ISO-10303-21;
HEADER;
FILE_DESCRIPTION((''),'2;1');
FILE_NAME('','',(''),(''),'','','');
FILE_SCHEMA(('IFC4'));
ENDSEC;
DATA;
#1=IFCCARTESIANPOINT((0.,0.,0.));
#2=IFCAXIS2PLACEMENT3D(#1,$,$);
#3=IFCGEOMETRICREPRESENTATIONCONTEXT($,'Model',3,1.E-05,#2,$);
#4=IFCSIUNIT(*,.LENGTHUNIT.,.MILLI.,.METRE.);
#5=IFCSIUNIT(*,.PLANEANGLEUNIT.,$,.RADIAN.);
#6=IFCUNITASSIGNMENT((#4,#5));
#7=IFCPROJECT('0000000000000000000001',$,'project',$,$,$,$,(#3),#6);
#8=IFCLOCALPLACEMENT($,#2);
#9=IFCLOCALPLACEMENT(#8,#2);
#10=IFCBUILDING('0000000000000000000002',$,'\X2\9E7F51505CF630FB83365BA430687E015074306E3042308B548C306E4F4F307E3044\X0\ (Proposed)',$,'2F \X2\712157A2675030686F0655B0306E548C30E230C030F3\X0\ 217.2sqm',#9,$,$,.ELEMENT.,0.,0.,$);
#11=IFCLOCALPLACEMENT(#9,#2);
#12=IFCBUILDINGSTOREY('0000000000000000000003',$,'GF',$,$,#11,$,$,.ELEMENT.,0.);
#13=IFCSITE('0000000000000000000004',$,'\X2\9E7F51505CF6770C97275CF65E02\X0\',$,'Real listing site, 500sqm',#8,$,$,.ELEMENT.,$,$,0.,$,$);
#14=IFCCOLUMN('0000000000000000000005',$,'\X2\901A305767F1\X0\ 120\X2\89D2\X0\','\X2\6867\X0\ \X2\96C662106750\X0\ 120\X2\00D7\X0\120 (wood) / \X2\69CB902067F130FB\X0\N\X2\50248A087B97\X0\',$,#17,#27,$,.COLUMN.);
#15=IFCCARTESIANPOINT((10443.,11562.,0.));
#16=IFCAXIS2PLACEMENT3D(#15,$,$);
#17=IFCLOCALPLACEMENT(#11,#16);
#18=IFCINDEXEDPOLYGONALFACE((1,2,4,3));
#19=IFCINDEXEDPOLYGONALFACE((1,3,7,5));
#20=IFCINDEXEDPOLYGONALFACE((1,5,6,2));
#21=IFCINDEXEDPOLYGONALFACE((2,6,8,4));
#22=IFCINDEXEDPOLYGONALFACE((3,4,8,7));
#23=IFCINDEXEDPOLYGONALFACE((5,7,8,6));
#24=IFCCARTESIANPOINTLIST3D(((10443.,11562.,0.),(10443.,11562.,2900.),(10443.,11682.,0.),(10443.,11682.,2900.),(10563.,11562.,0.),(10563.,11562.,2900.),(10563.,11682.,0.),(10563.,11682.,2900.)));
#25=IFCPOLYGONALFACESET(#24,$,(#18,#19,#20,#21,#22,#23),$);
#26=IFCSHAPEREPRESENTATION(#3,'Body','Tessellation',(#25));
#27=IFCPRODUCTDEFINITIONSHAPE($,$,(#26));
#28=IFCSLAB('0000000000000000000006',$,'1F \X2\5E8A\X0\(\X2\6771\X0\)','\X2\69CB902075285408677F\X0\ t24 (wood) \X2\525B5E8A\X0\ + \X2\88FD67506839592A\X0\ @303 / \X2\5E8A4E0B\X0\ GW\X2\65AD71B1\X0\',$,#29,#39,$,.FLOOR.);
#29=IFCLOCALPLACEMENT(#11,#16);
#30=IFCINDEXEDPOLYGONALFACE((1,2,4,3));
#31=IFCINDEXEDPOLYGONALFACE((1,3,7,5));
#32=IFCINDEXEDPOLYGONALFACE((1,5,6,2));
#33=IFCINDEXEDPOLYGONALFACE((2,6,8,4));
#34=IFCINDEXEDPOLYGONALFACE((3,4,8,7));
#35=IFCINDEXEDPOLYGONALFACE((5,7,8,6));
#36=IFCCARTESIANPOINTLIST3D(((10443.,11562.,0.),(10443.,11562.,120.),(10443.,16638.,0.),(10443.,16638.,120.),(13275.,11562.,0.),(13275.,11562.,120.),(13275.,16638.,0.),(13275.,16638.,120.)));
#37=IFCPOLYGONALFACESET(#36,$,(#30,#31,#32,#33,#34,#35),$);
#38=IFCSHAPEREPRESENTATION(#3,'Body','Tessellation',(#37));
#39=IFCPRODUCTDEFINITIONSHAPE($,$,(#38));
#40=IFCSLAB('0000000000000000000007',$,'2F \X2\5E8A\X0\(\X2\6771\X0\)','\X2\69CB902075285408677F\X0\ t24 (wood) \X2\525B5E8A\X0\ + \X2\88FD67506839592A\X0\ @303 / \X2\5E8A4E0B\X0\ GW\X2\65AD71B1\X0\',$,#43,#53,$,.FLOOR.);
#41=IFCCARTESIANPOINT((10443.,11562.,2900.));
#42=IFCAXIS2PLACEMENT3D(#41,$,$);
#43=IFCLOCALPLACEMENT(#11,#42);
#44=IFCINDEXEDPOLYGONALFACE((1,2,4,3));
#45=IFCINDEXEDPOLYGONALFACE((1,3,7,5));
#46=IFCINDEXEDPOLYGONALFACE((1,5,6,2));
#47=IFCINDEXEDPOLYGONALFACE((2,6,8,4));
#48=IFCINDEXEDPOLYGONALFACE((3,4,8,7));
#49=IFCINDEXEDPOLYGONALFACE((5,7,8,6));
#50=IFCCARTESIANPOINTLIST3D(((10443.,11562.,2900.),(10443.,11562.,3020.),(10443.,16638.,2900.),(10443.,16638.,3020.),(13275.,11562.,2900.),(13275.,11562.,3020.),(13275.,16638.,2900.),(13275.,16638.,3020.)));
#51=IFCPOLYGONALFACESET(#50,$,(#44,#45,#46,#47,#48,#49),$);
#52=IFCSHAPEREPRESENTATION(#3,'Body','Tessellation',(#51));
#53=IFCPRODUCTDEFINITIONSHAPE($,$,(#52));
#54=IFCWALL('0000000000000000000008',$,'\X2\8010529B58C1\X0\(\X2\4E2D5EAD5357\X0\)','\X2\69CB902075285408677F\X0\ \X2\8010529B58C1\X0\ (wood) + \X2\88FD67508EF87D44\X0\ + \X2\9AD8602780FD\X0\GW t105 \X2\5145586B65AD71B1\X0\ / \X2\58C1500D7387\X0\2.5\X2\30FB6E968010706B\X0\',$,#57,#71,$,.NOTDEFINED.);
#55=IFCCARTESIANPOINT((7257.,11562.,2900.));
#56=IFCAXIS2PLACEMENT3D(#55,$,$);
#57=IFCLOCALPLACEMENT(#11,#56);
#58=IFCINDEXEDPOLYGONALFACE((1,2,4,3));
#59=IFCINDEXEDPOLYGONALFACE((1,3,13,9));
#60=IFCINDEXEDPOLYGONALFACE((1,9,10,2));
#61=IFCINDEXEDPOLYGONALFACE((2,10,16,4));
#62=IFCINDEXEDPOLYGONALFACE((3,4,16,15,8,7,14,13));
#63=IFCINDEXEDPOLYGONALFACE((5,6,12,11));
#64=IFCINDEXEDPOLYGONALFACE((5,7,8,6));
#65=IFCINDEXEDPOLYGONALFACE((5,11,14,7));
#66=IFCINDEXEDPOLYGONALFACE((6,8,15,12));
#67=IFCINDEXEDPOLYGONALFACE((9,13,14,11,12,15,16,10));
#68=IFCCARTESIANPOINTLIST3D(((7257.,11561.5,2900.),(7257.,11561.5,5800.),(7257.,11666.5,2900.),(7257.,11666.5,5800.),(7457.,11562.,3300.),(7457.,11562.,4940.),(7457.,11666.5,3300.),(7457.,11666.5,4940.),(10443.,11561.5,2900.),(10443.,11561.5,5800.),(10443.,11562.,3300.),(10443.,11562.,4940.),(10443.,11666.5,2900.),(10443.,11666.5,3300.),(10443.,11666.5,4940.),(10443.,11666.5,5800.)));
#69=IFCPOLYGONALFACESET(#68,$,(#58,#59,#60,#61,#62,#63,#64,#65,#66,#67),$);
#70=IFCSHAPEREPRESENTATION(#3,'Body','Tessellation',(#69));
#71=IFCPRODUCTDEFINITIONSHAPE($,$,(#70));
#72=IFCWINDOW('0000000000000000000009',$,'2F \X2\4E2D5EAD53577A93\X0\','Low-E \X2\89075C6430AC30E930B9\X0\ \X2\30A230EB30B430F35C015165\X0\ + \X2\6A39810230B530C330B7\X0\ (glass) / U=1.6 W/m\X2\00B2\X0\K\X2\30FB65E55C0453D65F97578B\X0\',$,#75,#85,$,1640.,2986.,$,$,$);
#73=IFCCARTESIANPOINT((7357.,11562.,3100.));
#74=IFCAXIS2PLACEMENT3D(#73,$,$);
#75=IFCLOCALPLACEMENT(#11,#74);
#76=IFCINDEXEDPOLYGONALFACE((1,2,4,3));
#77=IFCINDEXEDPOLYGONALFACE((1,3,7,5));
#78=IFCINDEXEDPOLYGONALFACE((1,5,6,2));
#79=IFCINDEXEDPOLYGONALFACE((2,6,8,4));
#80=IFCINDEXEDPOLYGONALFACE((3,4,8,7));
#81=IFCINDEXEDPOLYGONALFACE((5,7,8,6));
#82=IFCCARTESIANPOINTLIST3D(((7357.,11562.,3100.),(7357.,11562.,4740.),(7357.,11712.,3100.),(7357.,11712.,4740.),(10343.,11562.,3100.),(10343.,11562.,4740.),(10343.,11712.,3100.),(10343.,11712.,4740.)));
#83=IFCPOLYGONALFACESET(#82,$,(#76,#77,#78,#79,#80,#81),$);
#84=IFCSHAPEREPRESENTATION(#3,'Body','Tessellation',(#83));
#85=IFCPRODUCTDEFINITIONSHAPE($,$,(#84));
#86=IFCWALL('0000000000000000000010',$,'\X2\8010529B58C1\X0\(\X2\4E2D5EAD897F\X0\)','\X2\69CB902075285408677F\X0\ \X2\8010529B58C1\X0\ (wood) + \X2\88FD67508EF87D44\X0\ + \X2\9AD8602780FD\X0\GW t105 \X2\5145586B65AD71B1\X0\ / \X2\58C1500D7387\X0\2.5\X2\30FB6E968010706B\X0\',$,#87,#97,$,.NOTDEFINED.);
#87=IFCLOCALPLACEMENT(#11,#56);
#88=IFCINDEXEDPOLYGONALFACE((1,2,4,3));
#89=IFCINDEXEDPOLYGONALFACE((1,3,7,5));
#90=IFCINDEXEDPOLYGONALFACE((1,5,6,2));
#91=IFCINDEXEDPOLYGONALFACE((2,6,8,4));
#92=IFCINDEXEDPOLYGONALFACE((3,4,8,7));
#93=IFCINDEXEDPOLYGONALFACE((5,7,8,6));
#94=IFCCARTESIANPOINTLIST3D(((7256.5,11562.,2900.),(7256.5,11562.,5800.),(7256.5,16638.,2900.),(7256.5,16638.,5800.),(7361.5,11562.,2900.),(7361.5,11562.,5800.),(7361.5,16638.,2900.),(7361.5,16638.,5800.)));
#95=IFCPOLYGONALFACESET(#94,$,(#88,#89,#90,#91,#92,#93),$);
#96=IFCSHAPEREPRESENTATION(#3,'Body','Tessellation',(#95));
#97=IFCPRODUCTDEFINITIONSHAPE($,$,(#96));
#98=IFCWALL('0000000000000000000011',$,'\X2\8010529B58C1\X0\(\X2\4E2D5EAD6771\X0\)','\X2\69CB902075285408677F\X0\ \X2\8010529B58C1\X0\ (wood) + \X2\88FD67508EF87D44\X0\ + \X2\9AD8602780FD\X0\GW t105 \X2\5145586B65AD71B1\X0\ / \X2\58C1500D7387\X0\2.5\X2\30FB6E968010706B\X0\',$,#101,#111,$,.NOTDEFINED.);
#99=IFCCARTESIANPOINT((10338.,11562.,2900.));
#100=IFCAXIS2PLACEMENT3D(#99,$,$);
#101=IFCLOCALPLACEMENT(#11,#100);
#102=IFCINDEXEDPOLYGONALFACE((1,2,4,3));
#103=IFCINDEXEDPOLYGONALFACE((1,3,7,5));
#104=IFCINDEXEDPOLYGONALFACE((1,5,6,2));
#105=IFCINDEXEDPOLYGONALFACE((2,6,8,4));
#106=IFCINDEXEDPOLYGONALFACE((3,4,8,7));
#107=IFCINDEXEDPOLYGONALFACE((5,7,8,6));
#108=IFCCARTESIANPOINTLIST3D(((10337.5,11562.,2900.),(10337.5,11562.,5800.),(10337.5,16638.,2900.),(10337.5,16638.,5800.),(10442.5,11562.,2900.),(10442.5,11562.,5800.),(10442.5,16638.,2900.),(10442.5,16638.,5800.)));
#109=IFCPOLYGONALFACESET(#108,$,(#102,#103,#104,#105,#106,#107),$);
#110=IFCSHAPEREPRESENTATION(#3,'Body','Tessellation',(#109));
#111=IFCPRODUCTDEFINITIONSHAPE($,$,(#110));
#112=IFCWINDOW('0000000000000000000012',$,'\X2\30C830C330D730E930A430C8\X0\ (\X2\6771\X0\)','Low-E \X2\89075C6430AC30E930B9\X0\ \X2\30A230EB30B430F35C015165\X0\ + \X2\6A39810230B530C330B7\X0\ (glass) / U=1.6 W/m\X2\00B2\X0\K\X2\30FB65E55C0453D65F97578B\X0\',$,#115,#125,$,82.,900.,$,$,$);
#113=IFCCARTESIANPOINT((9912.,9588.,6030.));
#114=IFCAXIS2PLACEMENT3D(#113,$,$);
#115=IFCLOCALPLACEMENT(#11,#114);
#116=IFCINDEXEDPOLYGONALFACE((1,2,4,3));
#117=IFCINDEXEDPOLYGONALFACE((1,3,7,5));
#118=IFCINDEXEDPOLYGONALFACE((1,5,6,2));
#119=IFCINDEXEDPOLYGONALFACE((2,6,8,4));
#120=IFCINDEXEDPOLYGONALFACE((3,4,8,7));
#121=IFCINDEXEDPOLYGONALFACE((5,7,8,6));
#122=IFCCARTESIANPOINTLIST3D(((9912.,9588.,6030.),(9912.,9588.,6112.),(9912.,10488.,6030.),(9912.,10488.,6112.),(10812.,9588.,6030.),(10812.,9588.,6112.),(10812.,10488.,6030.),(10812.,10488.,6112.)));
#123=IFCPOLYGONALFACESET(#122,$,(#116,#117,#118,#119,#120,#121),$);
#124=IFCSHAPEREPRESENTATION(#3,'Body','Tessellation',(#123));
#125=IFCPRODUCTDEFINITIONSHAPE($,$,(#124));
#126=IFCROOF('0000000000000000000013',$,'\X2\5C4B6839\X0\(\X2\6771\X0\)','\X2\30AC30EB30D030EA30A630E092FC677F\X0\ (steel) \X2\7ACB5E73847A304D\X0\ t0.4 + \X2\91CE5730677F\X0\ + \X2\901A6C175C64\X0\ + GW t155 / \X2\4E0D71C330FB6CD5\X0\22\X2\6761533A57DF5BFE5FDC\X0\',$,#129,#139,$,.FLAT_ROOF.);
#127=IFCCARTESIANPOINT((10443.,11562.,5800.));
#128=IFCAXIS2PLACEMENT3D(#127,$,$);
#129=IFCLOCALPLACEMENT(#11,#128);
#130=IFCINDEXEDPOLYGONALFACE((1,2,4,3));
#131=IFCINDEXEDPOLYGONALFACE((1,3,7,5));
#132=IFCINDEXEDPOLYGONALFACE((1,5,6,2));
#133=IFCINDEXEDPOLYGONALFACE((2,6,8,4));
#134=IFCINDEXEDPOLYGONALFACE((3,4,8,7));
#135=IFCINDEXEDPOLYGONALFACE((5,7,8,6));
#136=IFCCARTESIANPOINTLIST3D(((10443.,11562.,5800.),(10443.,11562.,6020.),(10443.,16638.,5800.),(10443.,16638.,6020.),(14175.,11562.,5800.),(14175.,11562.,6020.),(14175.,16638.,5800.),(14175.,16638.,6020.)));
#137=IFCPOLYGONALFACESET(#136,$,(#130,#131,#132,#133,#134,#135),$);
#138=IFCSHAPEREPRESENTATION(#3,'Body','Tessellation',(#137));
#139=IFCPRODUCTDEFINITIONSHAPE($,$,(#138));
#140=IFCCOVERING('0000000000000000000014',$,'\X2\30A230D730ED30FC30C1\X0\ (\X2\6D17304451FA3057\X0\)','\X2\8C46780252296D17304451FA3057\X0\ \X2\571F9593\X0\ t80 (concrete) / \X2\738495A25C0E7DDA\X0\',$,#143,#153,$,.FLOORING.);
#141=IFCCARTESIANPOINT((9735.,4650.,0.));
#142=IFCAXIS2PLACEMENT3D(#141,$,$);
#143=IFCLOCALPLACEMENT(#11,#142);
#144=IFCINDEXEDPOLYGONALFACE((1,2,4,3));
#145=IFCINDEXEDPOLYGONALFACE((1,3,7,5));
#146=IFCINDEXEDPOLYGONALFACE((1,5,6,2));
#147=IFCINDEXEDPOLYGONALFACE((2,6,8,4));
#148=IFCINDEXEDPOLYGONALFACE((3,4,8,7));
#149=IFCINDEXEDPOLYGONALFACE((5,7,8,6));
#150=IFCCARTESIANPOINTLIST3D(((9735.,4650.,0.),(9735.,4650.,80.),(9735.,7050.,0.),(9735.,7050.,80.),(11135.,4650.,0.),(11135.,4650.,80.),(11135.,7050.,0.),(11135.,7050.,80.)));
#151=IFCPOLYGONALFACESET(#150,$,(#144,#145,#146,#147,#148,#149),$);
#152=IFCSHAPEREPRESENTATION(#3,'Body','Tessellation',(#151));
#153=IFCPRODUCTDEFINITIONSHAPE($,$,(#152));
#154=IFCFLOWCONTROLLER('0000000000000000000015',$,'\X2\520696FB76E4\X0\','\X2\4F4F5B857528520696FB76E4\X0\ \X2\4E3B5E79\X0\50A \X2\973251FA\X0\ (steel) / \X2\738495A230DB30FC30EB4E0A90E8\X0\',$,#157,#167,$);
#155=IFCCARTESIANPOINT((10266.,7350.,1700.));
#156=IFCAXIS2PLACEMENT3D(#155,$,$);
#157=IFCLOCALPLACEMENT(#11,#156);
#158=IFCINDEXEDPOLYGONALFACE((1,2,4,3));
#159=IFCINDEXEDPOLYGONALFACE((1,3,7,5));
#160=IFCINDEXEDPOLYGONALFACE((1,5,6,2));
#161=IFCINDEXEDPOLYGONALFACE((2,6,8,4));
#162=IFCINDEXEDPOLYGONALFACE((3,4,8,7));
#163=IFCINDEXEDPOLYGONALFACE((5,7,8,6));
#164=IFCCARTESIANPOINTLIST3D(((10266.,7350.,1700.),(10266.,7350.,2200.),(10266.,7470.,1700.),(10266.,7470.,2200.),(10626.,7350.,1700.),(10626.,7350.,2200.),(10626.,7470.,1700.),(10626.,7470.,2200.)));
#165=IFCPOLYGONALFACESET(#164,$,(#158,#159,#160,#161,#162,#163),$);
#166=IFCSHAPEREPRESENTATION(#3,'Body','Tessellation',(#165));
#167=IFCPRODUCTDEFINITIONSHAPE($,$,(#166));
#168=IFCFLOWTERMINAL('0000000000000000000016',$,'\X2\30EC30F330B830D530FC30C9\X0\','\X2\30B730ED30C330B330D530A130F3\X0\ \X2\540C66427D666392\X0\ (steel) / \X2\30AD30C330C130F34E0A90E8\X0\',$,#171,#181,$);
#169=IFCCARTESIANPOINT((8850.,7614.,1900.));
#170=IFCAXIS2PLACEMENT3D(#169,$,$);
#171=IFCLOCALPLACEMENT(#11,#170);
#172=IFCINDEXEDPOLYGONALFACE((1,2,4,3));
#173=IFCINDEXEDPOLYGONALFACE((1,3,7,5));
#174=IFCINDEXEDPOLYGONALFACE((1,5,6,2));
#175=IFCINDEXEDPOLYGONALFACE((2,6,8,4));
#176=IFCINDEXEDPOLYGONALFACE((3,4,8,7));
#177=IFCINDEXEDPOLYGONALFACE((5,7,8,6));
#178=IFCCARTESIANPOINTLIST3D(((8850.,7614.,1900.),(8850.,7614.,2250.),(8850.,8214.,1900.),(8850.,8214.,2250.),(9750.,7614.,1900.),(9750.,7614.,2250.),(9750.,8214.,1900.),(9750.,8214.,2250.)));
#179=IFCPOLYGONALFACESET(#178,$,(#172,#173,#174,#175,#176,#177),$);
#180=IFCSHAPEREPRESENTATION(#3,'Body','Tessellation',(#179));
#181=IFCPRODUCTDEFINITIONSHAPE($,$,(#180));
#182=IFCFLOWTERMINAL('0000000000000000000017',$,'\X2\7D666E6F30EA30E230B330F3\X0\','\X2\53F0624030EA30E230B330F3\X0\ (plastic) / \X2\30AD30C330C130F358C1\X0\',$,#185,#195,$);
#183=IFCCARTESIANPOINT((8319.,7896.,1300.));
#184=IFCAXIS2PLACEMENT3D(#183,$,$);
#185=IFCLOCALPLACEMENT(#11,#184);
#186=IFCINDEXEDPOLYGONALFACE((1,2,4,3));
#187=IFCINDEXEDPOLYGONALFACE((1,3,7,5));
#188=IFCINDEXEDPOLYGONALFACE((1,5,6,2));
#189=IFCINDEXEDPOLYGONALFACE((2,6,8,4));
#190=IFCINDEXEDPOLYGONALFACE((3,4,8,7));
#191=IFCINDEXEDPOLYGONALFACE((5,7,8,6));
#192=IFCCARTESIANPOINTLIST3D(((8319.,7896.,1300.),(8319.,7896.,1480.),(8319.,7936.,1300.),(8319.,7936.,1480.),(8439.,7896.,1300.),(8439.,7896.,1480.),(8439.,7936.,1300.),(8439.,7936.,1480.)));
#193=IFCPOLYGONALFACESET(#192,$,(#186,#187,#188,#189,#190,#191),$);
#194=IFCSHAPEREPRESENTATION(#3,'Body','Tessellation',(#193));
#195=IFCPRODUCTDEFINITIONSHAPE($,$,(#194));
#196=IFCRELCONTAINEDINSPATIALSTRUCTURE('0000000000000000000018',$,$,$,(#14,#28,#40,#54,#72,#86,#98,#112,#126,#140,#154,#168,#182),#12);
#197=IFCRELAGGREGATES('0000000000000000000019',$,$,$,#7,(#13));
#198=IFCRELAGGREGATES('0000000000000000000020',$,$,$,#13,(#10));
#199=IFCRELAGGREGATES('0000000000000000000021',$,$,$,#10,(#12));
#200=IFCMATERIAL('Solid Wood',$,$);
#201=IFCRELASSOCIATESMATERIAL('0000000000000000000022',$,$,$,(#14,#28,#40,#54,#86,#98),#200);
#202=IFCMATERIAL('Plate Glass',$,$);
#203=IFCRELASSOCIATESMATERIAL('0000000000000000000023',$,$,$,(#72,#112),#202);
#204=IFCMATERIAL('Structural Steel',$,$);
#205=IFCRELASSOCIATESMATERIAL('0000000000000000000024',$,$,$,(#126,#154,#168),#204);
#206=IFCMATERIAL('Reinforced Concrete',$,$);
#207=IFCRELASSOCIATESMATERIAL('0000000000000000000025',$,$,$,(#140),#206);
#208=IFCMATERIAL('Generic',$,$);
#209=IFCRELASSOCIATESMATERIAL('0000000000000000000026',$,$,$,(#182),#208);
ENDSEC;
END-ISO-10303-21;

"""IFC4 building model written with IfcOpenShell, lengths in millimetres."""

from ifc_helpers import new_model, si_unit, frame, frame_2d, origin, place, context, project, spatial, rectangle, extrude, material, element, fill, save


model = new_model("IFC4")

# Units and contexts
model_context = context("Model", 3, precision=1e-05, world=origin())
ifc_project = project(units=[si_unit("LENGTHUNIT", "METRE", prefix="MILLI"), si_unit("PLANEANGLEUNIT", "RADIAN")], contexts=[model_context])

# Site, building, storey
site_placement = place(None, origin())
site = spatial("IfcSite", under=ifc_project, at=site_placement, Name="鹿児島県霧島市", ObjectType="Real listing site, 500sqm", CompositionType="ELEMENT", RefElevation=0.0)
building_placement = place(site_placement, origin())
building = spatial("IfcBuilding", under=site, at=building_placement, Name="鹿児島・茶室と縁側のある和の住まい (Proposed)", ObjectType="2F 無垢材と漆喰の和モダン 217.2sqm", CompositionType="ELEMENT", ElevationOfRefHeight=0.0, ElevationOfTerrain=0.0)
storey_placement = place(building_placement, origin())
storey = spatial("IfcBuildingStorey", under=building, at=storey_placement, Name="GF", CompositionType="ELEMENT", Elevation=0.0)

# Column
ifc_material_1 = material(Name="Solid Wood")
column_1_placement = place(storey_placement, frame((10443.0, 11562.0, 0.0)))
element("IfcColumn", 1, at=column_1_placement, inside=storey, material=ifc_material_1, Name="通し柱 120角", Description="桧 集成材 120×120 (wood) / 構造柱・N値計算", PredefinedType="COLUMN", context=model_context, shape_type="SweptSolid", body=[
    extrude(rectangle(XDim=120.0, YDim=120.0, at=frame_2d((60.0, 60.0))), frame((10443.0, 11562.0, 0.0)), (0.0, 0.0, 1.0), 2900.0),
])

# Slabs
slab_1_placement = place(storey_placement, frame((10443.0, 11562.0, 0.0)))
element("IfcSlab", 2, at=slab_1_placement, inside=storey, material=ifc_material_1, Name="1F 床(東)", Description="構造用合板 t24 (wood) 剛床 + 製材根太 @303 / 床下 GW断熱", PredefinedType="FLOOR", context=model_context, shape_type="SweptSolid", body=[
    extrude(rectangle(XDim=2832.0, YDim=5076.0, at=frame_2d((1416.0, 2538.0))), frame((10443.0, 11562.0, 0.0)), (0.0, 0.0, 1.0), 120.0),
])
slab_2_placement = place(storey_placement, frame((10443.0, 11562.0, 2900.0)))
element("IfcSlab", 3, at=slab_2_placement, inside=storey, material=ifc_material_1, Name="2F 床(東)", Description="構造用合板 t24 (wood) 剛床 + 製材根太 @303 / 床下 GW断熱", PredefinedType="FLOOR", context=model_context, shape_type="SweptSolid", body=[
    extrude(rectangle(XDim=2832.0, YDim=5076.0, at=frame_2d((1416.0, 2538.0))), frame((10443.0, 11562.0, 2900.0)), (0.0, 0.0, 1.0), 120.0),
])

# Wall, opening, window
wall_1_placement = place(storey_placement, frame((7257.0, 11562.0, 2900.0)))
wall_1 = element("IfcWall", 4, at=wall_1_placement, inside=storey, material=ifc_material_1, Name="耐力壁(中庭南)", Description="構造用合板 耐力壁 (wood) + 製材軸組 + 高性能GW t105 充填断熱 / 壁倍率2.5・準耐火", PredefinedType="NOTDEFINED", context=model_context, shape_type="SweptSolid", body=[
    extrude(rectangle(XDim=3186.0, YDim=105.0, at=frame_2d((1593.0, 52.0))), frame((7257.0, 11562.0, 2900.0)), (0.0, 0.0, 1.0), 2900.0),
])
opening_placement = place(storey_placement, frame((7357.0, 11562.0, 3100.0)))
opening = element("IfcOpeningElement", 5, at=opening_placement, cuts=wall_1, PredefinedType="NOTDEFINED", context=model_context, shape_type="SweptSolid", body=[
    extrude(rectangle(XDim=2986.0, YDim=150.0, at=frame_2d((1493.0, 75.0))), frame((7357.0, 11562.0, 3100.0)), (0.0, 0.0, 1.0), 1640.0),
])
ifc_material_2 = material(Name="Plate Glass")
window_1_placement = place(storey_placement, frame((7357.0, 11562.0, 3100.0)))
window_1 = element("IfcWindow", 6, at=window_1_placement, inside=storey, material=ifc_material_2, Name="2F 中庭南窓", Description="Low-E 複層ガラス アルゴン封入 + 樹脂サッシ (glass) / U=1.6 W/m²K・日射取得型", OverallHeight=1640.0, OverallWidth=2986.0, context=model_context, shape_type="SweptSolid", body=[
    extrude(rectangle(XDim=2986.0, YDim=150.0, at=frame_2d((1493.0, 75.0))), frame((7357.0, 11562.0, 3100.0)), (0.0, 0.0, 1.0), 1640.0),
])
fill(opening, window_1)

# Walls
wall_2_placement = place(storey_placement, frame((7257.0, 11562.0, 2900.0)))
element("IfcWall", 7, at=wall_2_placement, inside=storey, material=ifc_material_1, Name="耐力壁(中庭西)", Description="構造用合板 耐力壁 (wood) + 製材軸組 + 高性能GW t105 充填断熱 / 壁倍率2.5・準耐火", PredefinedType="NOTDEFINED", context=model_context, shape_type="SweptSolid", body=[
    extrude(rectangle(XDim=105.0, YDim=5076.0, at=frame_2d((52.0, 2538.0))), frame((7257.0, 11562.0, 2900.0)), (0.0, 0.0, 1.0), 2900.0),
])
wall_3_placement = place(storey_placement, frame((10338.0, 11562.0, 2900.0)))
element("IfcWall", 8, at=wall_3_placement, inside=storey, material=ifc_material_1, Name="耐力壁(中庭東)", Description="構造用合板 耐力壁 (wood) + 製材軸組 + 高性能GW t105 充填断熱 / 壁倍率2.5・準耐火", PredefinedType="NOTDEFINED", context=model_context, shape_type="SweptSolid", body=[
    extrude(rectangle(XDim=105.0, YDim=5076.0, at=frame_2d((52.0, 2538.0))), frame((10338.0, 11562.0, 2900.0)), (0.0, 0.0, 1.0), 2900.0),
])

# Window
window_2_placement = place(storey_placement, frame((9912.0, 9588.0, 6030.0)))
element("IfcWindow", 9, at=window_2_placement, inside=storey, material=ifc_material_2, Name="トップライト (東)", Description="Low-E 複層ガラス アルゴン封入 + 樹脂サッシ (glass) / U=1.6 W/m²K・日射取得型", OverallHeight=82.0, OverallWidth=900.0, context=model_context, shape_type="SweptSolid", body=[
    extrude(rectangle(XDim=900.0, YDim=900.0, at=frame_2d((450.0, 450.0))), frame((9912.0, 9588.0, 6030.0)), (0.0, 0.0, 1.0), 82.0),
])

# Roof
ifc_material_3 = material(Name="Structural Steel")
for number, where, name in (
    (10, (10443.0, 11562.0, 5800.0), "屋根(東)"),
):
    element("IfcRoof", number, at=place(storey_placement, frame(where)), inside=storey, material=ifc_material_3, Name=name, Description="ガルバリウム鋼板 (steel) 立平葺き t0.4 + 野地板 + 通気層 + GW t155 / 不燃・法22条区域対応", PredefinedType="FLAT_ROOF", context=model_context, shape_type="SweptSolid", body=[
        extrude(rectangle(XDim=3732.0, YDim=5076.0, at=frame_2d((1866.0, 2538.0))), frame((10443.0, 11562.0, 5800.0)), (0.0, 0.0, 1.0), 220.0),
    ])

# Covering
ifc_material_4 = material(Name="Reinforced Concrete")
covering_placement = place(storey_placement, frame((9735.0, 4650.0, 0.0)))
element("IfcCovering", 11, at=covering_placement, inside=storey, material=ifc_material_4, Name="アプローチ (洗い出し)", Description="豆砂利洗い出し 土間 t80 (concrete) / 玄関導線", PredefinedType="FLOORING", context=model_context, shape_type="SweptSolid", body=[
    extrude(rectangle(XDim=1400.0, YDim=2400.0, at=frame_2d((700.0, 1200.0))), frame((9735.0, 4650.0, 0.0)), (0.0, 0.0, 1.0), 80.0),
])

# Flow controller
flow_controller_placement = place(storey_placement, frame((10266.0, 7350.0, 1700.0)))
element("IfcFlowController", 12, at=flow_controller_placement, inside=storey, material=ifc_material_3, Name="分電盤", Description="住宅用分電盤 主幹50A 露出 (steel) / 玄関ホール上部", context=model_context, shape_type="SweptSolid", body=[
    extrude(rectangle(XDim=360.0, YDim=120.0, at=frame_2d((180.0, 60.0))), frame((10266.0, 7350.0, 1700.0)), (0.0, 0.0, 1.0), 500.0),
])

# Flow terminals
flow_terminal_1_placement = place(storey_placement, frame((8850.0, 7614.0, 1900.0)))
element("IfcFlowTerminal", 13, at=flow_terminal_1_placement, inside=storey, material=ifc_material_3, Name="レンジフード", Description="シロッコファン 同時給排 (steel) / キッチン上部", context=model_context, shape_type="SweptSolid", body=[
    extrude(rectangle(XDim=900.0, YDim=600.0, at=frame_2d((450.0, 300.0))), frame((8850.0, 7614.0, 1900.0)), (0.0, 0.0, 1.0), 350.0),
])
ifc_material_5 = material(Name="Generic")
flow_terminal_2_placement = place(storey_placement, frame((8319.0, 7896.0, 1300.0)))
element("IfcFlowTerminal", 14, at=flow_terminal_2_placement, inside=storey, material=ifc_material_5, Name="給湯リモコン", Description="台所リモコン (plastic) / キッチン壁", context=model_context, shape_type="SweptSolid", body=[
    extrude(rectangle(XDim=120.0, YDim=40.0, at=frame_2d((60.0, 20.0))), frame((8319.0, 7896.0, 1300.0)), (0.0, 0.0, 1.0), 180.0),
])

save(model, "model.ifc")
